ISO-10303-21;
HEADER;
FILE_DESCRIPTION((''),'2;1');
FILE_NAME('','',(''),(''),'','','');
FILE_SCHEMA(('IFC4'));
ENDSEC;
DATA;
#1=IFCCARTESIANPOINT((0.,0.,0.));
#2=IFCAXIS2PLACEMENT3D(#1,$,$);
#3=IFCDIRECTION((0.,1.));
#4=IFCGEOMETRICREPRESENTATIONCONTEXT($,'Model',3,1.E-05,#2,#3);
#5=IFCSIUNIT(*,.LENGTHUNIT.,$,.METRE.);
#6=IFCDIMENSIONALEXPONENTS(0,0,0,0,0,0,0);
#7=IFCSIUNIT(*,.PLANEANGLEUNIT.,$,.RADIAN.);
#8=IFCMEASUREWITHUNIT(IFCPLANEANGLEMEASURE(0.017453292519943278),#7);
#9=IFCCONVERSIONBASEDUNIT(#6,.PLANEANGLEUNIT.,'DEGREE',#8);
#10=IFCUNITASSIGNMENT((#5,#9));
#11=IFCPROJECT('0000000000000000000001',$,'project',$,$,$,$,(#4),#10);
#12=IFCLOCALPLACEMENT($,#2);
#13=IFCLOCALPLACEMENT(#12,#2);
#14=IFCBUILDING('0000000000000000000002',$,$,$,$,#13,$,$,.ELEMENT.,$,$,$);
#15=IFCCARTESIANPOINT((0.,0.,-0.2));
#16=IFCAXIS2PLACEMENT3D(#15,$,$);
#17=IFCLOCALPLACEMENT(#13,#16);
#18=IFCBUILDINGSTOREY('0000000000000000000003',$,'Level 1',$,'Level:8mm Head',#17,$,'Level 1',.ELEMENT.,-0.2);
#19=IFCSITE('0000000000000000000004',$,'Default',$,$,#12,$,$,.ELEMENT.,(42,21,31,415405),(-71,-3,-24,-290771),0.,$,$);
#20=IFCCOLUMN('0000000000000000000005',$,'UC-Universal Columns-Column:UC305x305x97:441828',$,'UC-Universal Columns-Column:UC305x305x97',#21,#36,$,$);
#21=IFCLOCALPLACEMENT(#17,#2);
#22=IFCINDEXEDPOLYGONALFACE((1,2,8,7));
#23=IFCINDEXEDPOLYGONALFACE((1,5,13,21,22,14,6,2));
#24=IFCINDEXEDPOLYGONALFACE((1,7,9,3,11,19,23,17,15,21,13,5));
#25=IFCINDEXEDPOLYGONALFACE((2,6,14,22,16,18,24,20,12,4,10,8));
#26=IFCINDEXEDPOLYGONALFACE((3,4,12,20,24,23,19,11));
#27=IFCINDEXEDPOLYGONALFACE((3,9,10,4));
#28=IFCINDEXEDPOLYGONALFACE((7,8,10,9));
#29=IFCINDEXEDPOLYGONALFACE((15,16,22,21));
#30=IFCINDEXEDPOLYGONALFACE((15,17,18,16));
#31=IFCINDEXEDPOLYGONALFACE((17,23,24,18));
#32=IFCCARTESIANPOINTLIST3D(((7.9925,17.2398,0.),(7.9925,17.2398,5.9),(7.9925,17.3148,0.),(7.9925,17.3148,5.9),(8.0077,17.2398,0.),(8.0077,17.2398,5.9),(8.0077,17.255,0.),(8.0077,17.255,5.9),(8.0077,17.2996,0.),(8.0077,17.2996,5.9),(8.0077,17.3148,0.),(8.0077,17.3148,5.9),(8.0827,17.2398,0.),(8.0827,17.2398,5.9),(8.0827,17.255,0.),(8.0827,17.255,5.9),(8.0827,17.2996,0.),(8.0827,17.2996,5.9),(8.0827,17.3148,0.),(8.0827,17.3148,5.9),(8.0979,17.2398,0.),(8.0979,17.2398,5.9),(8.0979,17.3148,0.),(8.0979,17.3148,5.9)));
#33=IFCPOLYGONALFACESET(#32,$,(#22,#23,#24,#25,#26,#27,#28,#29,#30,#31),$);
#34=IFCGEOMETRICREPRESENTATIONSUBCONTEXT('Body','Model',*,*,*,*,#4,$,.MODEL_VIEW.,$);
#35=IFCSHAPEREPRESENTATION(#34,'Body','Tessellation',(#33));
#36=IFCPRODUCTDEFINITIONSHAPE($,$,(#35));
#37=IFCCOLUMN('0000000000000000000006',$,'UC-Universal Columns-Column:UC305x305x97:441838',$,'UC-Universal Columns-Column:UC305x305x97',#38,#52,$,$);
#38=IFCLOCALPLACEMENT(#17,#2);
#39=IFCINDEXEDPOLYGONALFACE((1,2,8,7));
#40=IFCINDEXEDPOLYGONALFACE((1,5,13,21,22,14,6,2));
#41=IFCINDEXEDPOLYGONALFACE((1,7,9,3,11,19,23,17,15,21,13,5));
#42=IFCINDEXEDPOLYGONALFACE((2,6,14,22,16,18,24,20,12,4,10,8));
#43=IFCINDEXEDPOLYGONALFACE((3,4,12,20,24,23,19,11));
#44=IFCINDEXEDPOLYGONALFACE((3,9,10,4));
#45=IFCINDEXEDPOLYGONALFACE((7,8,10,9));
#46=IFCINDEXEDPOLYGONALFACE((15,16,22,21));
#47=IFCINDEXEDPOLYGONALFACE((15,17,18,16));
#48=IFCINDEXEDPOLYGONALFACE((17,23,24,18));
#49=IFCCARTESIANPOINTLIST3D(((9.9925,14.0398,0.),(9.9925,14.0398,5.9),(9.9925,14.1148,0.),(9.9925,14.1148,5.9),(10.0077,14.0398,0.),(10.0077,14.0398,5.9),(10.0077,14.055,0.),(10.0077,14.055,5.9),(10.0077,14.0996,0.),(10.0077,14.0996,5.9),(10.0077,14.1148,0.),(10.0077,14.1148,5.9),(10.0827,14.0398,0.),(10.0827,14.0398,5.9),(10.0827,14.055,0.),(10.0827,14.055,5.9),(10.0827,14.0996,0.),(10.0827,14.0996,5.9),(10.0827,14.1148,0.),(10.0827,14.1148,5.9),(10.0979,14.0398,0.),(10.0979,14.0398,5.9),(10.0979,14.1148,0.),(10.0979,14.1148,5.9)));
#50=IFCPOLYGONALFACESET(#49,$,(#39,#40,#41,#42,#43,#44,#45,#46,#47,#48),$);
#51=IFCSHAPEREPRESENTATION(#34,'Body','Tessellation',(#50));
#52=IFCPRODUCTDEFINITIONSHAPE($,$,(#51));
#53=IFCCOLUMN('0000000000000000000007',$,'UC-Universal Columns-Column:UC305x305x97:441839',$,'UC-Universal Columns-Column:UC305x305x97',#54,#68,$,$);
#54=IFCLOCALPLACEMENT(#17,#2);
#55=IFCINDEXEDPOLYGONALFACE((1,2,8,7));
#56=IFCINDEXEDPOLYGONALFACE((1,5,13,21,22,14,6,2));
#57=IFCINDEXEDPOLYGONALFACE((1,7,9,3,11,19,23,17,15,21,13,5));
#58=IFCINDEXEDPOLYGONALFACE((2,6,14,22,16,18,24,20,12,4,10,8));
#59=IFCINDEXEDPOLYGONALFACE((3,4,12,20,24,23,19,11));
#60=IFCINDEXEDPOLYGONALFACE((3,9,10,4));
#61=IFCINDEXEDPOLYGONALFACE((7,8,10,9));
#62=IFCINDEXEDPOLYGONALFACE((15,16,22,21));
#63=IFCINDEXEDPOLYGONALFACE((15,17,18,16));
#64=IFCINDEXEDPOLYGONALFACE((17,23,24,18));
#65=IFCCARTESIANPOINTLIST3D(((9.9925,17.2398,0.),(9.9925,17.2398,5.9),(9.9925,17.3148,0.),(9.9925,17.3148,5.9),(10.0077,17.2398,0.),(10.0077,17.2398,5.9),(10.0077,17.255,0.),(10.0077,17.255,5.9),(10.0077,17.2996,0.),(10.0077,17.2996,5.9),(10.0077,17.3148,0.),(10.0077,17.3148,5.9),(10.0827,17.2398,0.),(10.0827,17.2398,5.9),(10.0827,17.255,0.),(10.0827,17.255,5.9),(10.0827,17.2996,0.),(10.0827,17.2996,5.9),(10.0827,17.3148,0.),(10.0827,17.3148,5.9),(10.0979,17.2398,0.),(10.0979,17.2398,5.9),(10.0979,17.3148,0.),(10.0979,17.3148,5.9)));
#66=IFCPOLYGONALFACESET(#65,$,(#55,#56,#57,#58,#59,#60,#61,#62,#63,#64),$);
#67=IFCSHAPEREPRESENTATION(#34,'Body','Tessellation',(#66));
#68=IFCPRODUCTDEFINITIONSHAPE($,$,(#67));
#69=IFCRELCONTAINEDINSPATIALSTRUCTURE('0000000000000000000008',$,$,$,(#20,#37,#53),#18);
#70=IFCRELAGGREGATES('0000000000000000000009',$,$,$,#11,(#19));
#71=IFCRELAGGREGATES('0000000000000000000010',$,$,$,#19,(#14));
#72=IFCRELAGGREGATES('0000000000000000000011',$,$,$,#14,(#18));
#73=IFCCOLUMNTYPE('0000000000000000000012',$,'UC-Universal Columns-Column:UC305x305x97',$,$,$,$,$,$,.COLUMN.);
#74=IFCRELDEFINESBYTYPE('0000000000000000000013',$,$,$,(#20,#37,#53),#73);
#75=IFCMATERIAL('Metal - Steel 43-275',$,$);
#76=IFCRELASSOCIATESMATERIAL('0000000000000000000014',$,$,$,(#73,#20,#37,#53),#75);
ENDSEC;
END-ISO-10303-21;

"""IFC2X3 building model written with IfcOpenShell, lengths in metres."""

from ifc_helpers import new_model, entity, si_unit, converted_unit, direction, frame, frame_2d, origin, place, context, subcontext, project, spatial, polyline, circle_curve, parameter, trimmed, segment, composite_curve, outline, extrude, source, transform, mapped, material, type_object, type_shapes, element, save


model = new_model("IFC2X3")

# Units and contexts
model_context = context("Model", 3, precision=1e-05, world=origin(), true_north=direction((0.0, 1.0)))
body_context = subcontext(model_context, "Body", "Model", "MODEL_VIEW")
ifc_project = project(units=[si_unit("LENGTHUNIT", "METRE"), converted_unit("PLANEANGLEUNIT", "DEGREE", entity("IfcPlaneAngleMeasure", 0.017453292519943278), si_unit("PLANEANGLEUNIT", "RADIAN"), dimensions=[0, 0, 0, 0, 0, 0, 0])], contexts=[model_context])

# Site, building, storey
site_placement = place(None, origin())
site = spatial("IfcSite", under=ifc_project, at=site_placement, Name="Default", CompositionType="ELEMENT", RefLatitude=(42, 21, 31, 415405), RefLongitude=(-71, -3, -24, -290771), RefElevation=0.0)
building_placement = place(site_placement, origin())
building = spatial("IfcBuilding", under=site, at=building_placement, CompositionType="ELEMENT")
storey_placement = place(building_placement, frame((0.0, 0.0, -0.2)))
storey = spatial("IfcBuildingStorey", under=building, at=storey_placement, Name="Level 1", ObjectType="Level:8mm Head", LongName="Level 1", CompositionType="ELEMENT", Elevation=-0.2)

# Columns
ifc_material = material(Name="Metal - Steel 43-275")
column_type = type_object("IfcColumnType", Name="UC-Universal Columns-Column:UC305x305x97", PredefinedType="COLUMN", material=ifc_material)
shared_shape = source(origin(), body_context, "Body", "SweptSolid", [
    extrude(outline(composite_curve([segment(polyline([(-0.0375, -0.0375), (0.0375, -0.0375)]), True, "CONTINUOUS"), segment(polyline([(0.0375, -0.0375), (0.0527, -0.0375)]), True, "CONTINUOUS"), segment(trimmed(circle_curve(frame_2d((0.0527, -0.0223), x_axis=(-1.0, 0.0)), 0.0152), [parameter(0.0)], [parameter(90.0)], True, "PARAMETER"), False, "CONTINUOUS"), segment(polyline([(0.0375, -0.0223), (0.0375, 0.0223)]), True, "CONTINUOUS"), segment(trimmed(circle_curve(frame_2d((0.0527, 0.0223), x_axis=(-1.0, 0.0)), 0.0152), [parameter(270.0)], [parameter(0.0)], True, "PARAMETER"), False, "CONTINUOUS"), segment(polyline([(0.0527, 0.0375), (0.0375, 0.0375)]), True, "CONTINUOUS"), segment(polyline([(0.0375, 0.0375), (-0.0375, 0.0375)]), True, "CONTINUOUS"), segment(polyline([(-0.0375, 0.0375), (-0.0527, 0.0375)]), True, "CONTINUOUS"), segment(trimmed(circle_curve(frame_2d((-0.0527, 0.0223), x_axis=(-1.0, 0.0)), 0.0152), [parameter(180.0)], [parameter(270.0)], True, "PARAMETER"), False, "CONTINUOUS"), segment(polyline([(-0.0375, 0.0223), (-0.0375, -0.0223)]), True, "CONTINUOUS"), segment(trimmed(circle_curve(frame_2d((-0.0527, -0.0223), x_axis=(-1.0, 0.0)), 0.0152), [parameter(90.0)], [parameter(180.0)], True, "PARAMETER"), False, "CONTINUOUS"), segment(polyline([(-0.0527, -0.0375), (-0.0375, -0.0375)]), True, "CONTINUOUS")], self_intersect=False)), frame((0.0, 0.0, -0.2), z_axis=(0.0, 0.0, 1.0), x_axis=(-1.0, 0.0, 0.0)), (0.0, 0.0, 1.0), 5.9),
])
type_shapes(column_type, [shared_shape])
for number, where, z_axis, x_axis, name in (
    (1, (8.0452, 17.2773, 0.2), (0.0, 0.0, 1.0), (-1.0, 0.0, 0.0), "UC-Universal Columns-Column:UC305x305x97:441828"),
    (2, (10.0452, 14.0773, 0.2), (0.0, 0.0, 1.0), (-1.0, 0.0, 0.0), "UC-Universal Columns-Column:UC305x305x97:441838"),
    (3, (10.0452, 17.2773, 0.2), (0.0, 0.0, 1.0), (-1.0, 0.0, 0.0), "UC-Universal Columns-Column:UC305x305x97:441839"),
):
    element("IfcColumn", number, at=place(storey_placement, frame(where, z_axis=z_axis, x_axis=x_axis)), inside=storey, type_object=column_type, material=ifc_material, Name=name, ObjectType="UC-Universal Columns-Column:UC305x305x97", context=body_context, shape_type="MappedRepresentation", body=[
        mapped(shared_shape, transform((0.0, 0.0, 0.0), scale=1.0)),
    ])

save(model, "model.ifc")
